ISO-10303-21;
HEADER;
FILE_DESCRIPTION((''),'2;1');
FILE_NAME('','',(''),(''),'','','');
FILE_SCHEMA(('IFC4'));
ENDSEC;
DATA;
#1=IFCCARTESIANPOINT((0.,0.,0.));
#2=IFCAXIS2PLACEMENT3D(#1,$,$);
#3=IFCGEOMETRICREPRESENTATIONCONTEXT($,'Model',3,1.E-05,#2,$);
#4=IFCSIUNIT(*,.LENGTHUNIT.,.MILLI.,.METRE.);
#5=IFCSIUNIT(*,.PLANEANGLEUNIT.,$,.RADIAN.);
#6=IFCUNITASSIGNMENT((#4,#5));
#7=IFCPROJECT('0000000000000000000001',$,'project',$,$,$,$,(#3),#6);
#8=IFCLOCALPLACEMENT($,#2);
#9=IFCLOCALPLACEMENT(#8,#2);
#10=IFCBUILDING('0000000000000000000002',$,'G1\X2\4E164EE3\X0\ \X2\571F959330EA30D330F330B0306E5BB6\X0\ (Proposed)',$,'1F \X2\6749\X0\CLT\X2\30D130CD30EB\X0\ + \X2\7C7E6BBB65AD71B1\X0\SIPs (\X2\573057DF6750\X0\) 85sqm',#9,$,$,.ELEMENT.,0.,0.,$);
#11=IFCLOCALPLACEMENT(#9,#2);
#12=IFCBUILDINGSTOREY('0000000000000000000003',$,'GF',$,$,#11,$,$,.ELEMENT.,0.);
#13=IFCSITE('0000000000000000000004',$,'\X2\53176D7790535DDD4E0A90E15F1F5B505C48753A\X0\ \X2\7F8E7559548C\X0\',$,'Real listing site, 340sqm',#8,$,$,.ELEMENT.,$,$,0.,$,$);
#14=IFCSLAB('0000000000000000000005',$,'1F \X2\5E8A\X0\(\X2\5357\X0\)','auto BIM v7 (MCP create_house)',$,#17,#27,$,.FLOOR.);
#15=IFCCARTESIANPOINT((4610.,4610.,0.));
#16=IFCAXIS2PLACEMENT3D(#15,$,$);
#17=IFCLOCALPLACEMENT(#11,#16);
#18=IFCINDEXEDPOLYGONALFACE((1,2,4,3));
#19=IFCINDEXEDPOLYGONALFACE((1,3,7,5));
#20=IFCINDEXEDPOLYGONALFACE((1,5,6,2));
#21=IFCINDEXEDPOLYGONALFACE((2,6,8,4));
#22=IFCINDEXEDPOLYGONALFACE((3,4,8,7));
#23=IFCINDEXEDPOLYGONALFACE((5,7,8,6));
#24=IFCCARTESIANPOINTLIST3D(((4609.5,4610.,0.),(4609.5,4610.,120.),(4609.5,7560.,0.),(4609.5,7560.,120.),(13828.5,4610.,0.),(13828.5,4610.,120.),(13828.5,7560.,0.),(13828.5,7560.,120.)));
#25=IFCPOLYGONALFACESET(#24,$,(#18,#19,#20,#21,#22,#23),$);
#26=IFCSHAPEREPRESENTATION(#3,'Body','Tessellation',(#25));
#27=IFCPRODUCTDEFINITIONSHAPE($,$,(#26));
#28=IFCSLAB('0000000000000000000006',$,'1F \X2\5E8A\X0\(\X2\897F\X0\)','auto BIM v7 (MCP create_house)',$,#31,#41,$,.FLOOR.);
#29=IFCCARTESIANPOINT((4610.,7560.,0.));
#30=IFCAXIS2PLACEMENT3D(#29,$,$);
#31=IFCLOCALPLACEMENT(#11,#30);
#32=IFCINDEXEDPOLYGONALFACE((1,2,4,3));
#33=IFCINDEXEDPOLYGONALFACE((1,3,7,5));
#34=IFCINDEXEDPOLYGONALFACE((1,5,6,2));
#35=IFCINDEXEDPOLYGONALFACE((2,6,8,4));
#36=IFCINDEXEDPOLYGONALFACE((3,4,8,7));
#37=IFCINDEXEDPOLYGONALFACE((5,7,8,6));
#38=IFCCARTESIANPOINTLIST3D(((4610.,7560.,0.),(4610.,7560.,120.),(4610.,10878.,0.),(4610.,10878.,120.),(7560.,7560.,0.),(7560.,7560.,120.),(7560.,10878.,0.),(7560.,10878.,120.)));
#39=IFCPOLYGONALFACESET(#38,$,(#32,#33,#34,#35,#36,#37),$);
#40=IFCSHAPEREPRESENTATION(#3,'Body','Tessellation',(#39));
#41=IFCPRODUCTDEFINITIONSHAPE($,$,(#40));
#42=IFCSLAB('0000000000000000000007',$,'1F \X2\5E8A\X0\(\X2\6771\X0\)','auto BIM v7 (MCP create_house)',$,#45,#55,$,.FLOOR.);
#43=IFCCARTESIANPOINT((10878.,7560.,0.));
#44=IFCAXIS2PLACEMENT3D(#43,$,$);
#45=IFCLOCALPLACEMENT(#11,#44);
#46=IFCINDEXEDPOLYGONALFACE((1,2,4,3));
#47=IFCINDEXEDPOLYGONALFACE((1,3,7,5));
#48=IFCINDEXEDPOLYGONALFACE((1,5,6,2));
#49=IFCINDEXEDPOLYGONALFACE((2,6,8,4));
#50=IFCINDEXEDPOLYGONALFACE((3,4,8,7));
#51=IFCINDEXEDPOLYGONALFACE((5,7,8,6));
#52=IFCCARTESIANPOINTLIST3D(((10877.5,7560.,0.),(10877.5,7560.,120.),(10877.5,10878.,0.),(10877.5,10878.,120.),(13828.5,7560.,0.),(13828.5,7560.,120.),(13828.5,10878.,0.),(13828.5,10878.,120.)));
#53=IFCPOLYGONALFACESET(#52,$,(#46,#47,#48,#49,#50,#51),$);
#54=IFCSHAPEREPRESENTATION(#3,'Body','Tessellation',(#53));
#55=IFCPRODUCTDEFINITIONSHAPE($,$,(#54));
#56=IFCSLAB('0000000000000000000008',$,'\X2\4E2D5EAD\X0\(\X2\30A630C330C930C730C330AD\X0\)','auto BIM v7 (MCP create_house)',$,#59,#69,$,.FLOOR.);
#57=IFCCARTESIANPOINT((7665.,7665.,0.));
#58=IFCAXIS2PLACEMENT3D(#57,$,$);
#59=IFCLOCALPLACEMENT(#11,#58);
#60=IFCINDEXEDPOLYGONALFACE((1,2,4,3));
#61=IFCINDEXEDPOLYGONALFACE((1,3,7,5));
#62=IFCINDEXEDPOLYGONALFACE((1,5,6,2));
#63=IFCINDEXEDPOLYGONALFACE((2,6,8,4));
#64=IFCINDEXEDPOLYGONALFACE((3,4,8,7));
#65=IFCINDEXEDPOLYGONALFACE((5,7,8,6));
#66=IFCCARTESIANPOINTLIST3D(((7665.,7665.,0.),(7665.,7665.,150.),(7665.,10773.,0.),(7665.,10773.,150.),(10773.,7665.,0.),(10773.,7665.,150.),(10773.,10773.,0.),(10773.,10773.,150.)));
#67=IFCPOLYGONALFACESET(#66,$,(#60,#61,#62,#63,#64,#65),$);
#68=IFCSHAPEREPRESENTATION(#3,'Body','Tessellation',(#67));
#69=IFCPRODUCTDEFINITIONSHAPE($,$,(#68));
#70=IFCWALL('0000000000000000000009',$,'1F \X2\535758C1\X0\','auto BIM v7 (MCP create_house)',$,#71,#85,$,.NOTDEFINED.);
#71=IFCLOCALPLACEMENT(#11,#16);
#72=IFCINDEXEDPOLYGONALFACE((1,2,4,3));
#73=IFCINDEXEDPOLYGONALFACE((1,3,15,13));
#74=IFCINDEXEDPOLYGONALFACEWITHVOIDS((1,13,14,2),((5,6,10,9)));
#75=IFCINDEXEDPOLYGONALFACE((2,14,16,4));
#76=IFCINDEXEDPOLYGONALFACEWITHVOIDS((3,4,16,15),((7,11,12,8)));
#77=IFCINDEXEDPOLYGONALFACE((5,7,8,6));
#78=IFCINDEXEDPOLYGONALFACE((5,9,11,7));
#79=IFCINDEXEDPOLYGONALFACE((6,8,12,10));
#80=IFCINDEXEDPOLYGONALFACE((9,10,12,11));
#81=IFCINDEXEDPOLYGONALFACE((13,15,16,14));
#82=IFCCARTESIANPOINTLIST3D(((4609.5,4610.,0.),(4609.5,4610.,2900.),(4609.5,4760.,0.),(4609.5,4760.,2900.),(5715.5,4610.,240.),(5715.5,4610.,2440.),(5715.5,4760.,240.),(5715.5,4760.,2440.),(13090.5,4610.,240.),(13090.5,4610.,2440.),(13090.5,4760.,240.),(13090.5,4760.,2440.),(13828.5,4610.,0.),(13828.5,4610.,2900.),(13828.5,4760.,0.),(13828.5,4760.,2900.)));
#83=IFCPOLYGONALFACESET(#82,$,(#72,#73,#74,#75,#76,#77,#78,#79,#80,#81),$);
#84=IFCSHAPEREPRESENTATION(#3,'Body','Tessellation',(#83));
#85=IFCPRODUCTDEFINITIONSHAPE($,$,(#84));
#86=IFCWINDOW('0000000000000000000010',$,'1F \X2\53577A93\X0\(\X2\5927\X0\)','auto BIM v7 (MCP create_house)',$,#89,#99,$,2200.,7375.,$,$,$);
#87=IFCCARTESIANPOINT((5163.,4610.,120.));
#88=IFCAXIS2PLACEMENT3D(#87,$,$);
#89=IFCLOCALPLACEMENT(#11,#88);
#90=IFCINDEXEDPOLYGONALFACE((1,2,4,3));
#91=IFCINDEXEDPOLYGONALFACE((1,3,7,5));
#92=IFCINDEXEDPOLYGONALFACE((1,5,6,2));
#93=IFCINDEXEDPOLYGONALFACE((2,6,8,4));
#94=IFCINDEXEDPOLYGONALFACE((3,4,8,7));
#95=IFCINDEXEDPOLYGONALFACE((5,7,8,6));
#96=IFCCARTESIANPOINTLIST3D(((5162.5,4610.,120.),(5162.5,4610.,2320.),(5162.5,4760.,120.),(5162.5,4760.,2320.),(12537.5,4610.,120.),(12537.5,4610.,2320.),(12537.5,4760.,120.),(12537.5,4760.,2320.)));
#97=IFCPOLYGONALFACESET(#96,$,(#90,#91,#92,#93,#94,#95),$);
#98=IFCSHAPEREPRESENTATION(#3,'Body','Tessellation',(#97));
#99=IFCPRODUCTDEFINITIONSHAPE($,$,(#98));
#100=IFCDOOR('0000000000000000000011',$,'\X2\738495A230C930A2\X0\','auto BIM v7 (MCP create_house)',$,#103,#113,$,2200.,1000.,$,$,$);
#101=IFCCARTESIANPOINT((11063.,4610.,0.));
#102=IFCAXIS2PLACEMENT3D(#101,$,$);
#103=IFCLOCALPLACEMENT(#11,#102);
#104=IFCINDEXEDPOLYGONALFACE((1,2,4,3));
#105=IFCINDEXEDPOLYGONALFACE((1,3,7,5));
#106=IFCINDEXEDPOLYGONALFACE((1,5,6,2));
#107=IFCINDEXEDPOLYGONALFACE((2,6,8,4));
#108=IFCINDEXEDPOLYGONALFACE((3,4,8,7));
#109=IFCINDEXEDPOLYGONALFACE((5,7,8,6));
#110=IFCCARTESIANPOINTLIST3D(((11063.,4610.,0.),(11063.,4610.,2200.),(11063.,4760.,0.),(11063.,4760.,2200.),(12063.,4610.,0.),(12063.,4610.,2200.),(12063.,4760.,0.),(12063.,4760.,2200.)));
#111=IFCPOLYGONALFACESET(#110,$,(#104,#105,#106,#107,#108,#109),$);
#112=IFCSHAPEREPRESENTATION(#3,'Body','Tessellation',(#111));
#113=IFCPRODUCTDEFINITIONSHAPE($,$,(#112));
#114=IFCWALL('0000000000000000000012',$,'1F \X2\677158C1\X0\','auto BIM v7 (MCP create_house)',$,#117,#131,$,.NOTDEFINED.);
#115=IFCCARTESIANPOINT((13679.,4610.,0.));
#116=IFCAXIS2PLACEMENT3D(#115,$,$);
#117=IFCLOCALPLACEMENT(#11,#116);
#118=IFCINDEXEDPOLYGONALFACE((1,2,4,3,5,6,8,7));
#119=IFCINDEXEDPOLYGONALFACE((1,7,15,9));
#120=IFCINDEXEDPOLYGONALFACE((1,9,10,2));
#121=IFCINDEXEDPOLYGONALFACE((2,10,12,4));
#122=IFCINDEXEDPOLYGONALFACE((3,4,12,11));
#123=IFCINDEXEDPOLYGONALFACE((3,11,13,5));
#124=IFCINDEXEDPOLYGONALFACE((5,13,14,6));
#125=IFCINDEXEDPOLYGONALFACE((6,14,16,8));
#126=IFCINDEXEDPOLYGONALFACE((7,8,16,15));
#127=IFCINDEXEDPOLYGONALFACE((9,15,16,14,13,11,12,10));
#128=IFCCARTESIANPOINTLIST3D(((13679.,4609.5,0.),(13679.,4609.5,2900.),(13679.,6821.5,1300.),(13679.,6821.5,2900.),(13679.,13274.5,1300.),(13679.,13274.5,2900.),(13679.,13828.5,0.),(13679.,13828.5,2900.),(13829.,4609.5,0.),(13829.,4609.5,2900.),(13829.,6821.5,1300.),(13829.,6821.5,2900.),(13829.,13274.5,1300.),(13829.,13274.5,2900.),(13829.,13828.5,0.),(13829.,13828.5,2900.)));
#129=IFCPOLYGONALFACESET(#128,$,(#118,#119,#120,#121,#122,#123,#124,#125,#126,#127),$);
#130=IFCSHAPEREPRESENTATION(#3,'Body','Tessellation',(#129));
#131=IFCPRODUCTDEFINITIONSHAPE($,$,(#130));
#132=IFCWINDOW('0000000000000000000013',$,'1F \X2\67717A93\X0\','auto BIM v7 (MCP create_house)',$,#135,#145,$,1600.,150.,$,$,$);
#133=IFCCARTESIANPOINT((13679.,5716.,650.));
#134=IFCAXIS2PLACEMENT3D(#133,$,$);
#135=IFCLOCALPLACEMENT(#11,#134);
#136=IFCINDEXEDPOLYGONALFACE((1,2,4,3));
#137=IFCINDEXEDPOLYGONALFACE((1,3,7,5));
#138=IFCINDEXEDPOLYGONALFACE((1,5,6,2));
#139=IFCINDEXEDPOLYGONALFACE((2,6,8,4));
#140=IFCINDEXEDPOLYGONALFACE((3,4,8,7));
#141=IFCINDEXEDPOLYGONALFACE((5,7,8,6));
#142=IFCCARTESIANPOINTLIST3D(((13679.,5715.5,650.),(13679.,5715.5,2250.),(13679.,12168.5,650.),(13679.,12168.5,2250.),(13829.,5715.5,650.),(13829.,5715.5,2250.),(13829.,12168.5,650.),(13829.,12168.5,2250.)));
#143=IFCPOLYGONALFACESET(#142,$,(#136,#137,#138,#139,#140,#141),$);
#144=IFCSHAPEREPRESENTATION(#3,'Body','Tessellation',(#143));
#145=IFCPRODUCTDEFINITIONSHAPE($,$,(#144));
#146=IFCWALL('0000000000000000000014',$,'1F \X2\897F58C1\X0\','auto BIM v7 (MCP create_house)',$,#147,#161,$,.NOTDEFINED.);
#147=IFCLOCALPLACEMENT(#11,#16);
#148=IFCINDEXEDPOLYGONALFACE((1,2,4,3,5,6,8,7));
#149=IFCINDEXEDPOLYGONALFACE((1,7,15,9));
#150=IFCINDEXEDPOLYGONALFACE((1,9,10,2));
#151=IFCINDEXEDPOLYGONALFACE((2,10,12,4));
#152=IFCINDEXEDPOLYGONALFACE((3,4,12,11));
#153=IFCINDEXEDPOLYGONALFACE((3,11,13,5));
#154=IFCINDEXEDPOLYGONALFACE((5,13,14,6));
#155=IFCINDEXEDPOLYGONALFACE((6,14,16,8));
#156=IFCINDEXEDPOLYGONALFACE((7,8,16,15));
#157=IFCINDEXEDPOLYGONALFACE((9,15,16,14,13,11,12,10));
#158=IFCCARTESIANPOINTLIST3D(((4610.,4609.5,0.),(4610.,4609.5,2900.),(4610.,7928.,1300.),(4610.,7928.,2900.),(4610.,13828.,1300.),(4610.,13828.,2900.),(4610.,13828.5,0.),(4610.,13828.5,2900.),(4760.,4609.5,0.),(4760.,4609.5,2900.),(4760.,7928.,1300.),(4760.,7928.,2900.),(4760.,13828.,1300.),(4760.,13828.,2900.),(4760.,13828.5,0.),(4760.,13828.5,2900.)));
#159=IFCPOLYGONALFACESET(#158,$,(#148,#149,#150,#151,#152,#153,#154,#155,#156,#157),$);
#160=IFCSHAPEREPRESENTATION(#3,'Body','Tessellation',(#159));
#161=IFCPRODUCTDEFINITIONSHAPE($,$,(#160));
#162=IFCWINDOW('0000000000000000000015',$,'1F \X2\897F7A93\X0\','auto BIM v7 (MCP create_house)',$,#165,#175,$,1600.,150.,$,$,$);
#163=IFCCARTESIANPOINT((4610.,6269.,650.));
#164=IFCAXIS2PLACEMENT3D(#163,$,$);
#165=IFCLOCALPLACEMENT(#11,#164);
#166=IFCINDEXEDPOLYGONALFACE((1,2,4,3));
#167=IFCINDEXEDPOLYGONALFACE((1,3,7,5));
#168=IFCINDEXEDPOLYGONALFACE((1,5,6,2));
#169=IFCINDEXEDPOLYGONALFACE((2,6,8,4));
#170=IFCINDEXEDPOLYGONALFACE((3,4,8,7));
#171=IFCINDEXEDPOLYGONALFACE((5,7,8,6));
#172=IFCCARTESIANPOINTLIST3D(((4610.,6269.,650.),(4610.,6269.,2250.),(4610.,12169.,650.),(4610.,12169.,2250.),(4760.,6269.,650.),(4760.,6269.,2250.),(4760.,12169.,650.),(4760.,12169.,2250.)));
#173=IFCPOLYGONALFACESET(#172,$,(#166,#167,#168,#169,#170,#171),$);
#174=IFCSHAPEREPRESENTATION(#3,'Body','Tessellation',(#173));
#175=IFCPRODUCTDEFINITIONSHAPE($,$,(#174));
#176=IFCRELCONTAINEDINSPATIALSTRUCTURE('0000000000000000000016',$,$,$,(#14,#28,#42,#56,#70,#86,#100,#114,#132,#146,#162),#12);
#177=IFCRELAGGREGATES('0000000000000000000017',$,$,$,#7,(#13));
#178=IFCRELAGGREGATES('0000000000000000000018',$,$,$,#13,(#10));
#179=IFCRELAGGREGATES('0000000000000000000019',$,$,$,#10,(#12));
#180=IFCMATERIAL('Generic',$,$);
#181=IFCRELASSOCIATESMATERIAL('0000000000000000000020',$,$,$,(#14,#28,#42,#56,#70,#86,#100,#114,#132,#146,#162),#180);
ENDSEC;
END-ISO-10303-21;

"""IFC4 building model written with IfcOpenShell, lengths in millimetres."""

from ifc_helpers import new_model, si_unit, frame, frame_2d, origin, place, context, project, spatial, rectangle, extrude, material, element, fill, save


model = new_model("IFC4")

# Units and contexts
model_context = context("Model", 3, precision=1e-05, world=origin())
ifc_project = project(units=[si_unit("LENGTHUNIT", "METRE", prefix="MILLI"), si_unit("PLANEANGLEUNIT", "RADIAN")], contexts=[model_context])

# Site, building, storey
site_placement = place(None, origin())
site = spatial("IfcSite", under=ifc_project, at=site_placement, Name="北海道川上郡弟子屈町 美留和", ObjectType="Real listing site, 340sqm", CompositionType="ELEMENT", RefElevation=0.0)
building_placement = place(site_placement, origin())
building = spatial("IfcBuilding", under=site, at=building_placement, Name="G1世代 土間リビングの家 (Proposed)", ObjectType="1F 杉CLTパネル + 籾殻断熱SIPs (地域材) 85sqm", CompositionType="ELEMENT", ElevationOfRefHeight=0.0, ElevationOfTerrain=0.0)
storey_placement = place(building_placement, origin())
storey = spatial("IfcBuildingStorey", under=building, at=storey_placement, Name="GF", CompositionType="ELEMENT", Elevation=0.0)

# Slabs
ifc_material = material(Name="Generic")
slab_1_placement = place(storey_placement, frame((4610.0, 4610.0, 0.0)))
element("IfcSlab", 1, at=slab_1_placement, inside=storey, material=ifc_material, Name="1F 床(南)", Description="auto BIM v7 (MCP create_house)", PredefinedType="FLOOR", context=model_context, shape_type="SweptSolid", body=[
    extrude(rectangle(XDim=9219.0, YDim=2950.0, at=frame_2d((4609.0, 1475.0))), frame((4610.0, 4610.0, 0.0)), (0.0, 0.0, 1.0), 120.0),
])
slab_2_placement = place(storey_placement, frame((4610.0, 7560.0, 0.0)))
element("IfcSlab", 2, at=slab_2_placement, inside=storey, material=ifc_material, Name="1F 床(西)", Description="auto BIM v7 (MCP create_house)", PredefinedType="FLOOR", context=model_context, shape_type="SweptSolid", body=[
    extrude(rectangle(XDim=2950.0, YDim=3318.0, at=frame_2d((1475.0, 1659.0))), frame((4610.0, 7560.0, 0.0)), (0.0, 0.0, 1.0), 120.0),
])
slab_3_placement = place(storey_placement, frame((10878.0, 7560.0, 0.0)))
element("IfcSlab", 3, at=slab_3_placement, inside=storey, material=ifc_material, Name="1F 床(東)", Description="auto BIM v7 (MCP create_house)", PredefinedType="FLOOR", context=model_context, shape_type="SweptSolid", body=[
    extrude(rectangle(XDim=2951.0, YDim=3318.0, at=frame_2d((1475.0, 1659.0))), frame((10878.0, 7560.0, 0.0)), (0.0, 0.0, 1.0), 120.0),
])
slab_4_placement = place(storey_placement, frame((7665.0, 7665.0, 0.0)))
element("IfcSlab", 4, at=slab_4_placement, inside=storey, material=ifc_material, Name="中庭(ウッドデッキ)", Description="auto BIM v7 (MCP create_house)", PredefinedType="FLOOR", context=model_context, shape_type="SweptSolid", body=[
    extrude(rectangle(XDim=3108.0, YDim=3108.0, at=frame_2d((1554.0, 1554.0))), frame((7665.0, 7665.0, 0.0)), (0.0, 0.0, 1.0), 150.0),
])

# Wall, openings, window, door
wall_1_placement = place(storey_placement, frame((4610.0, 4610.0, 0.0)))
wall_1 = element("IfcWall", 5, at=wall_1_placement, inside=storey, material=ifc_material, Name="1F 南壁", Description="auto BIM v7 (MCP create_house)", PredefinedType="NOTDEFINED", context=model_context, shape_type="SweptSolid", body=[
    extrude(rectangle(XDim=9219.0, YDim=150.0, at=frame_2d((4609.0, 75.0))), frame((4610.0, 4610.0, 0.0)), (0.0, 0.0, 1.0), 2900.0),
])
opening_1_placement = place(storey_placement, frame((5163.0, 4610.0, 120.0)))
opening_1 = element("IfcOpeningElement", 6, at=opening_1_placement, cuts=wall_1, PredefinedType="NOTDEFINED", context=model_context, shape_type="SweptSolid", body=[
    extrude(rectangle(XDim=7375.0, YDim=150.0, at=frame_2d((3687.0, 75.0))), frame((5163.0, 4610.0, 120.0)), (0.0, 0.0, 1.0), 2200.0),
])
opening_2_placement = place(storey_placement, frame((11063.0, 4610.0, 0.0)))
opening_2 = element("IfcOpeningElement", 7, at=opening_2_placement, cuts=wall_1, PredefinedType="NOTDEFINED", context=model_context, shape_type="SweptSolid", body=[
    extrude(rectangle(XDim=1000.0, YDim=150.0, at=frame_2d((500.0, 75.0))), frame((11063.0, 4610.0, 0.0)), (0.0, 0.0, 1.0), 2200.0),
])
window_1_placement = place(storey_placement, frame((5163.0, 4610.0, 120.0)))
window_1 = element("IfcWindow", 8, at=window_1_placement, inside=storey, material=ifc_material, Name="1F 南窓(大)", Description="auto BIM v7 (MCP create_house)", OverallHeight=2200.0, OverallWidth=7375.0, context=model_context, shape_type="SweptSolid", body=[
    extrude(rectangle(XDim=7375.0, YDim=150.0, at=frame_2d((3687.0, 75.0))), frame((5163.0, 4610.0, 120.0)), (0.0, 0.0, 1.0), 2200.0),
])
fill(opening_1, window_1)
door_placement = place(storey_placement, frame((11063.0, 4610.0, 0.0)))
door = element("IfcDoor", 9, at=door_placement, inside=storey, material=ifc_material, Name="玄関ドア", Description="auto BIM v7 (MCP create_house)", OverallHeight=2200.0, OverallWidth=1000.0, context=model_context, shape_type="SweptSolid", body=[
    extrude(rectangle(XDim=1000.0, YDim=150.0, at=frame_2d((500.0, 75.0))), frame((11063.0, 4610.0, 0.0)), (0.0, 0.0, 1.0), 2200.0),
])
fill(opening_2, door)

# Walls, openings, windows
wall_2_placement = place(storey_placement, frame((13679.0, 4610.0, 0.0)))
wall_2 = element("IfcWall", 10, at=wall_2_placement, inside=storey, material=ifc_material, Name="1F 東壁", Description="auto BIM v7 (MCP create_house)", PredefinedType="NOTDEFINED", context=model_context, shape_type="SweptSolid", body=[
    extrude(rectangle(XDim=150.0, YDim=9219.0, at=frame_2d((75.0, 4609.0))), frame((13679.0, 4610.0, 0.0)), (0.0, 0.0, 1.0), 2900.0),
])
opening_3_placement = place(storey_placement, frame((13679.0, 5716.0, 650.0)))
opening_3 = element("IfcOpeningElement", 11, at=opening_3_placement, cuts=wall_2, PredefinedType="NOTDEFINED", context=model_context, shape_type="SweptSolid", body=[
    extrude(rectangle(XDim=150.0, YDim=6453.0, at=frame_2d((75.0, 3226.0))), frame((13679.0, 5716.0, 650.0)), (0.0, 0.0, 1.0), 1600.0),
])
window_2_placement = place(storey_placement, frame((13679.0, 5716.0, 650.0)))
window_2 = element("IfcWindow", 12, at=window_2_placement, inside=storey, material=ifc_material, Name="1F 東窓", Description="auto BIM v7 (MCP create_house)", OverallHeight=1600.0, OverallWidth=150.0, context=model_context, shape_type="SweptSolid", body=[
    extrude(rectangle(XDim=150.0, YDim=6453.0, at=frame_2d((75.0, 3226.0))), frame((13679.0, 5716.0, 650.0)), (0.0, 0.0, 1.0), 1600.0),
])
fill(opening_3, window_2)
wall_3_placement = place(storey_placement, frame((4610.0, 4610.0, 0.0)))
wall_3 = element("IfcWall", 13, at=wall_3_placement, inside=storey, material=ifc_material, Name="1F 西壁", Description="auto BIM v7 (MCP create_house)", PredefinedType="NOTDEFINED", context=model_context, shape_type="SweptSolid", body=[
    extrude(rectangle(XDim=150.0, YDim=9219.0, at=frame_2d((75.0, 4609.0))), frame((4610.0, 4610.0, 0.0)), (0.0, 0.0, 1.0), 2900.0),
])
opening_4_placement = place(storey_placement, frame((4610.0, 6269.0, 650.0)))
opening_4 = element("IfcOpeningElement", 14, at=opening_4_placement, cuts=wall_3, PredefinedType="NOTDEFINED", context=model_context, shape_type="SweptSolid", body=[
    extrude(rectangle(XDim=150.0, YDim=5900.0, at=frame_2d((75.0, 2950.0))), frame((4610.0, 6269.0, 650.0)), (0.0, 0.0, 1.0), 1600.0),
])
window_3_placement = place(storey_placement, frame((4610.0, 6269.0, 650.0)))
window_3 = element("IfcWindow", 15, at=window_3_placement, inside=storey, material=ifc_material, Name="1F 西窓", Description="auto BIM v7 (MCP create_house)", OverallHeight=1600.0, OverallWidth=150.0, context=model_context, shape_type="SweptSolid", body=[
    extrude(rectangle(XDim=150.0, YDim=5900.0, at=frame_2d((75.0, 2950.0))), frame((4610.0, 6269.0, 650.0)), (0.0, 0.0, 1.0), 1600.0),
])
fill(opening_4, window_3)

save(model, "model.ifc")
